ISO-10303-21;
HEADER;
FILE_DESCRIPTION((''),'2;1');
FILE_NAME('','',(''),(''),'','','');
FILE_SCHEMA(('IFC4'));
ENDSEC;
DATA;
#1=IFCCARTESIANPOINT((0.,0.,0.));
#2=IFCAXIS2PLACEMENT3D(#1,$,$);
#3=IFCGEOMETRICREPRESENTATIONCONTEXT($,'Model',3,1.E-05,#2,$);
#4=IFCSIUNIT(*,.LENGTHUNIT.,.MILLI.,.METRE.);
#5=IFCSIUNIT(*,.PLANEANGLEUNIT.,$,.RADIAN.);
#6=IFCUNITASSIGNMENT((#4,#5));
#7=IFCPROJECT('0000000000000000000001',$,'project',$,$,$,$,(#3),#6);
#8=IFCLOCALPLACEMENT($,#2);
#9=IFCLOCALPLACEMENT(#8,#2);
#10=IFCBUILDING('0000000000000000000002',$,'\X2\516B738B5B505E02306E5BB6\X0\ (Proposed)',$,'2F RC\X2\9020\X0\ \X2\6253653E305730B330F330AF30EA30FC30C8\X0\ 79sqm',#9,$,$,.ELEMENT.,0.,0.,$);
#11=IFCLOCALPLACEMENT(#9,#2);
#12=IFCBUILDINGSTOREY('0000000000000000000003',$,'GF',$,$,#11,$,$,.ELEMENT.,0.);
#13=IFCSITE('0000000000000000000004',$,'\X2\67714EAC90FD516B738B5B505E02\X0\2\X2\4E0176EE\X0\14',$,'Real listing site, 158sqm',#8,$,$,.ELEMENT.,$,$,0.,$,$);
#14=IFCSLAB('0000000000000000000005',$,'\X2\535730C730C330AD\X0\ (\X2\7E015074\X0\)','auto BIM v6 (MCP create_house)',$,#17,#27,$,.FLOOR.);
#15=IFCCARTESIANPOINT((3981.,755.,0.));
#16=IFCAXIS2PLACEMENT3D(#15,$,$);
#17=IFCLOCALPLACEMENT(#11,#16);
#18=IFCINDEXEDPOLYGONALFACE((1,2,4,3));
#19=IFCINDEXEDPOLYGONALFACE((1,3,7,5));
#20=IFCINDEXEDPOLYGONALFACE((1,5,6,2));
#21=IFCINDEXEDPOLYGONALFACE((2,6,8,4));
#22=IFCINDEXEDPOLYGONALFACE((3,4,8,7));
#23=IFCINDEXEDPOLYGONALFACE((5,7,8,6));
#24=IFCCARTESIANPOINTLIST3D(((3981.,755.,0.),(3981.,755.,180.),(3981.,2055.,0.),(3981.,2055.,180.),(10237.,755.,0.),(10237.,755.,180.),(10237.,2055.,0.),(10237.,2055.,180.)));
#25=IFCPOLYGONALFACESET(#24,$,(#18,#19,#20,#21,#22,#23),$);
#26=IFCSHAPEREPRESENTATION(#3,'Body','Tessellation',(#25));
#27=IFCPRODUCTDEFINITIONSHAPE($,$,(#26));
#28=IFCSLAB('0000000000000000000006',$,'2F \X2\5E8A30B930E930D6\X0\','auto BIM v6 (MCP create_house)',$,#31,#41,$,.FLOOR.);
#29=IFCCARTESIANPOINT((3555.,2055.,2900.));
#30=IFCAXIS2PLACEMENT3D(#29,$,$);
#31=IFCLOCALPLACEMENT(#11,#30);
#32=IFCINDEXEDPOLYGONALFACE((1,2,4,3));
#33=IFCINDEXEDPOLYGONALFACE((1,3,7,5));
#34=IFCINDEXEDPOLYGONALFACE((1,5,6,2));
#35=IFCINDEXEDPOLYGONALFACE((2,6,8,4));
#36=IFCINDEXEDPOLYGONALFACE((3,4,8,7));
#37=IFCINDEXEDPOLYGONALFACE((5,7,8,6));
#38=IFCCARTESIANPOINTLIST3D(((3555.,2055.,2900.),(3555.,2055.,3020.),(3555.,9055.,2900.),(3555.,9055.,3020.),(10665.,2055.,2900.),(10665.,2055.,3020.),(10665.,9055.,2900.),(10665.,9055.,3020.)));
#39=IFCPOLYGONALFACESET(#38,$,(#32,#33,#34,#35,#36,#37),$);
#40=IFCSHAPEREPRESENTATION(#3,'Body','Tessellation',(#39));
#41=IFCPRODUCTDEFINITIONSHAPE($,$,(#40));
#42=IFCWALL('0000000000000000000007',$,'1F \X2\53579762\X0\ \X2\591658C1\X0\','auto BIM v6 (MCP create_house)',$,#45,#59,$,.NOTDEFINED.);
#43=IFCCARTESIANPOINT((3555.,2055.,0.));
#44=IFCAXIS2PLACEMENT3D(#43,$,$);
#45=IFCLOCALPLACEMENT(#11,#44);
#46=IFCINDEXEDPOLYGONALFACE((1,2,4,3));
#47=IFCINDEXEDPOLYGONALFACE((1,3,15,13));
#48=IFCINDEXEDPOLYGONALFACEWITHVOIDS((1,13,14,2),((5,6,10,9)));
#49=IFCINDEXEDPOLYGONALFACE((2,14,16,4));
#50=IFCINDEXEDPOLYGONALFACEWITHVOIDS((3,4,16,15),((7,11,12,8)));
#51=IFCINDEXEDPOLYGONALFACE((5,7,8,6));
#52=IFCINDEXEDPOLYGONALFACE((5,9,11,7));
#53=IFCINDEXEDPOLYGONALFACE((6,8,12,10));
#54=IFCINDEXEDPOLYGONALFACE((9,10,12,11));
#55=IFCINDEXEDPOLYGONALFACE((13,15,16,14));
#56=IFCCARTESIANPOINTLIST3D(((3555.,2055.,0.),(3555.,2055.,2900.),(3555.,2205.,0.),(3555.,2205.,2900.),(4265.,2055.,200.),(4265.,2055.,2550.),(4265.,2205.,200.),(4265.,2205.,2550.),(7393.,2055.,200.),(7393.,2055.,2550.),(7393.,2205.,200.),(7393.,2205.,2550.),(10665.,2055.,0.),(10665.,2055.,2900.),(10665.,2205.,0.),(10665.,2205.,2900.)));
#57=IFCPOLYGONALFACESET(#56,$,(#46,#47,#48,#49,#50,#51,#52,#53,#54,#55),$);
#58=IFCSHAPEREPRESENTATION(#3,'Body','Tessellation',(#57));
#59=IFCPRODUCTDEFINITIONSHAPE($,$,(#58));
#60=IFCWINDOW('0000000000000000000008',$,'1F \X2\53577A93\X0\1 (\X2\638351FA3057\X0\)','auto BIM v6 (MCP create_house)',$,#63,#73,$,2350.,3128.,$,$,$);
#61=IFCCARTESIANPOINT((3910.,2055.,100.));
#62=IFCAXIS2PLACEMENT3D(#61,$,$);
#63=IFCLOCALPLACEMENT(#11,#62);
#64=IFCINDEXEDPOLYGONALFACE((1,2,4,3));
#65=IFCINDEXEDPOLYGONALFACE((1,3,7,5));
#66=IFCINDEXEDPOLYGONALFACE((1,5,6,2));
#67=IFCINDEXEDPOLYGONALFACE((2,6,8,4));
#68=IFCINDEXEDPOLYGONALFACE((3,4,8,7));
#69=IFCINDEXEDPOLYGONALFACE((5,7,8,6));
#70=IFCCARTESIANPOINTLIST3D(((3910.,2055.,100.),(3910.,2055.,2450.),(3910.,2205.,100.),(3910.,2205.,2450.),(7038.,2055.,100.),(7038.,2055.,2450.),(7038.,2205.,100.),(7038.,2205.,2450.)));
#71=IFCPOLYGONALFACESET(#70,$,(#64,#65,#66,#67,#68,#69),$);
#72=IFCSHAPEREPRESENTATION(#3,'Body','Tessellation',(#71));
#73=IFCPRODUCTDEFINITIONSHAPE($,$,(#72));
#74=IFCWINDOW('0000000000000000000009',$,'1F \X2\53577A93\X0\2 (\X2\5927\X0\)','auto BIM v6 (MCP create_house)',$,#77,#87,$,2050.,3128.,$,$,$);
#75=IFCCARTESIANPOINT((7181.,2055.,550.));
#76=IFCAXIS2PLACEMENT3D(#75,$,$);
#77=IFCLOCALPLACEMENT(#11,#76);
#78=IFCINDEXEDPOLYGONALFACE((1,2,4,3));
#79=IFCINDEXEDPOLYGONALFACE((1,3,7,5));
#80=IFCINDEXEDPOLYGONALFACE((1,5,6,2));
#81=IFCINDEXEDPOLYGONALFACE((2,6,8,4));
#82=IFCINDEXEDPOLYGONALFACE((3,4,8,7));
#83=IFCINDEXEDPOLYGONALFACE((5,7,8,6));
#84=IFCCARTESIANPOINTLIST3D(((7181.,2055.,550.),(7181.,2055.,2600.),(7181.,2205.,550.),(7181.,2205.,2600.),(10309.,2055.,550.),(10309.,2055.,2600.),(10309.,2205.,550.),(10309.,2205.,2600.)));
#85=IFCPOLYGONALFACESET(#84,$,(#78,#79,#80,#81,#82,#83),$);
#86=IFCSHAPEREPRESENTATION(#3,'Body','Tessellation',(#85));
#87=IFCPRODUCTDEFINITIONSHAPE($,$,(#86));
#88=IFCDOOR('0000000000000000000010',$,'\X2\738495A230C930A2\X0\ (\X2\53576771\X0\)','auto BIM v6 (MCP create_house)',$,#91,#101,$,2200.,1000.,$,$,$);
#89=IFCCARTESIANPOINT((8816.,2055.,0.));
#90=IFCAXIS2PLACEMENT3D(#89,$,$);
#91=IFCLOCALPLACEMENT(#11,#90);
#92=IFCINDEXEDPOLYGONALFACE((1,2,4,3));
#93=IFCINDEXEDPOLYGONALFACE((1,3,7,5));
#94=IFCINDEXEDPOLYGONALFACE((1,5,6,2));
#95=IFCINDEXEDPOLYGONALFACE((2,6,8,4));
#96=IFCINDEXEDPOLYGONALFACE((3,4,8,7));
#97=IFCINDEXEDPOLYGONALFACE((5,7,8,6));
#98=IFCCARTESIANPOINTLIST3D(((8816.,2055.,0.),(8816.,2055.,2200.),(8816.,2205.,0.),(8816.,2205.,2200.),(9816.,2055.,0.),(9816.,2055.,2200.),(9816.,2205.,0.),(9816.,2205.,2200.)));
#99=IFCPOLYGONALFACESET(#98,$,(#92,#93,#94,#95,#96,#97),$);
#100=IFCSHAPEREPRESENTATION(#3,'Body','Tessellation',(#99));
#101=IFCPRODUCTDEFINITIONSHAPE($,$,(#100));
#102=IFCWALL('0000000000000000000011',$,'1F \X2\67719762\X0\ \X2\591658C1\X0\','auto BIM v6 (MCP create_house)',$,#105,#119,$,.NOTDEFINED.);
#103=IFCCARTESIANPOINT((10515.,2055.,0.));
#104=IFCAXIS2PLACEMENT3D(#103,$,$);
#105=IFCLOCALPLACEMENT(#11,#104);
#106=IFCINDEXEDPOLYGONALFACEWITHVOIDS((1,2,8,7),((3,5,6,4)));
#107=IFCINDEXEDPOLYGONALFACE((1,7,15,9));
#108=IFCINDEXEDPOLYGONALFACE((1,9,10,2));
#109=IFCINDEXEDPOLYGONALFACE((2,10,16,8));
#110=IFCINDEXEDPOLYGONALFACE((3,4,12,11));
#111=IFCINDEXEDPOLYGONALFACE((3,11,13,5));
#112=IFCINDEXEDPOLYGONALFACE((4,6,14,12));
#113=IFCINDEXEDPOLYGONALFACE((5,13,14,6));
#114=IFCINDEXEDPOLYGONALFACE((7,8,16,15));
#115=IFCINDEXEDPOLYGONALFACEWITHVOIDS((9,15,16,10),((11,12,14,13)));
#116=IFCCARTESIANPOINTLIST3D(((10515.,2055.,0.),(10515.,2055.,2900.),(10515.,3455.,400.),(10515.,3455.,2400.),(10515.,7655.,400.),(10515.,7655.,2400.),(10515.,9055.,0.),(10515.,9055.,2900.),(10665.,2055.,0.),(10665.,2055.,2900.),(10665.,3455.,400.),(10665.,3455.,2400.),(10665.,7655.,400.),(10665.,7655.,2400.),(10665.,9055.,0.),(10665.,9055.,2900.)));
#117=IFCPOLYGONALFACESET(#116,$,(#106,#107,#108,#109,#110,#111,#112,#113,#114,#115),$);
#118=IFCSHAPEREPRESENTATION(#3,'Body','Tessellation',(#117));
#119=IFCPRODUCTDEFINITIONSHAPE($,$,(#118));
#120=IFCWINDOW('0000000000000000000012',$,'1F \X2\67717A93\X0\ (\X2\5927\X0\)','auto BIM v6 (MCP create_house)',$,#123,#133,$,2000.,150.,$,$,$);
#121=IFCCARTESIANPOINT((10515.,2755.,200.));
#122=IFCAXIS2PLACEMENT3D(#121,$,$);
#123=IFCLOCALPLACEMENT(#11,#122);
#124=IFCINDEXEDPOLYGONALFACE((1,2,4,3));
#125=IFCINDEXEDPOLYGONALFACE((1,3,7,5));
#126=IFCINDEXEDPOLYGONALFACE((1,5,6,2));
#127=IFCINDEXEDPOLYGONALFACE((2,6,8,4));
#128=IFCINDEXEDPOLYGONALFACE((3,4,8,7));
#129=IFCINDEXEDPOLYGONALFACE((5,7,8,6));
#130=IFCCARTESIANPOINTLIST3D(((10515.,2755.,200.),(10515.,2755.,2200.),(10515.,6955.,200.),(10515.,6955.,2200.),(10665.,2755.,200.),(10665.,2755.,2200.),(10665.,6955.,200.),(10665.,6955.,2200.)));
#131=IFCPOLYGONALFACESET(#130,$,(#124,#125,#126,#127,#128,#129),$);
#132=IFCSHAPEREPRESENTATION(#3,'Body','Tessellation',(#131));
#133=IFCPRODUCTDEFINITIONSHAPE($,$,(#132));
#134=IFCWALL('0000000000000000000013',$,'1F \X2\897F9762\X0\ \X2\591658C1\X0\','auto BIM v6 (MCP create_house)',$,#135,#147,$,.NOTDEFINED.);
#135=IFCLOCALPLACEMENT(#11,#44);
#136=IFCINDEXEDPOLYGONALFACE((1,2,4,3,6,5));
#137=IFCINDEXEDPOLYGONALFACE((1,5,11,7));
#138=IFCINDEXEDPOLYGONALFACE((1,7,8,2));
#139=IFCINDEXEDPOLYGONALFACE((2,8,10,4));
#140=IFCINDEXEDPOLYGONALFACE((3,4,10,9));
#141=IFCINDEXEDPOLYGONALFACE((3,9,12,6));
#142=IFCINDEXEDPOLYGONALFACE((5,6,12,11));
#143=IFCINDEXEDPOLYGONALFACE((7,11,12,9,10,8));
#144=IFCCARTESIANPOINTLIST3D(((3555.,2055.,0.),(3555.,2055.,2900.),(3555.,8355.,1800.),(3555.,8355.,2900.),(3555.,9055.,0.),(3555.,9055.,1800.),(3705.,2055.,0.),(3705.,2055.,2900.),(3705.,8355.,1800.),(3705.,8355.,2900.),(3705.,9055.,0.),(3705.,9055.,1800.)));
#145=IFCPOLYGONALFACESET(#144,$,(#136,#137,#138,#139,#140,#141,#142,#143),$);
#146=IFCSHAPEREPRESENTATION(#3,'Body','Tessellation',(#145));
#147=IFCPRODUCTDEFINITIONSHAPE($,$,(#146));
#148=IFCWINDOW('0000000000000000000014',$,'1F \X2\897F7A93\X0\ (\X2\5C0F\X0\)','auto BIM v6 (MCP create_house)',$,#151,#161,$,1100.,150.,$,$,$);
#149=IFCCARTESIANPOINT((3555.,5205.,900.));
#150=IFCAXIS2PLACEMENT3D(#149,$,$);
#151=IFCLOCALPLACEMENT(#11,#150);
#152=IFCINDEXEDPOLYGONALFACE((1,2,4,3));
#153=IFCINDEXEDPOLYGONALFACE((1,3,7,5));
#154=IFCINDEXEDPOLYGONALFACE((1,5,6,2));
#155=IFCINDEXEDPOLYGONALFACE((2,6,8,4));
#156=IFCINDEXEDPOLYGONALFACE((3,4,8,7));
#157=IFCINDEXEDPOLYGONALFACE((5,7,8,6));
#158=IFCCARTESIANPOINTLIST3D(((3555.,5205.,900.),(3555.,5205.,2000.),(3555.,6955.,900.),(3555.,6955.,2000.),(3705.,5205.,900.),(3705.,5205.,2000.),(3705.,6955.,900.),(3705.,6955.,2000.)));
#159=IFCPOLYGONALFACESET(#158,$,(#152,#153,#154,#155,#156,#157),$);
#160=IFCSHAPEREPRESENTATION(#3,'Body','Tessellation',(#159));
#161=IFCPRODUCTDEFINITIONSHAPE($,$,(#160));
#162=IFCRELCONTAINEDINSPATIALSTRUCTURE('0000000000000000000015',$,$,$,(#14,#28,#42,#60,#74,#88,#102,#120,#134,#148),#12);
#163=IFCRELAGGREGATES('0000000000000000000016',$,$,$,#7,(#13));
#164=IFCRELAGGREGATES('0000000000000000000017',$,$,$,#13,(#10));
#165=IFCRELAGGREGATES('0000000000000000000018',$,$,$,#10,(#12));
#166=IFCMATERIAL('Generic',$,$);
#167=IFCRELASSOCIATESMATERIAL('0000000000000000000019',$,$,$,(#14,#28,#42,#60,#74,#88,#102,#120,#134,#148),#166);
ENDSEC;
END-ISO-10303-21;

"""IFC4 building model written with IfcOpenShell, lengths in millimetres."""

from ifc_helpers import new_model, si_unit, frame, frame_2d, origin, place, context, project, spatial, rectangle, extrude, material, element, fill, save


model = new_model("IFC4")

# Units and contexts
model_context = context("Model", 3, precision=1e-05, world=origin())
ifc_project = project(units=[si_unit("LENGTHUNIT", "METRE", prefix="MILLI"), si_unit("PLANEANGLEUNIT", "RADIAN")], contexts=[model_context])

# Site, building, storey
site_placement = place(None, origin())
site = spatial("IfcSite", under=ifc_project, at=site_placement, Name="東京都八王子市2丁目14", ObjectType="Real listing site, 158sqm", CompositionType="ELEMENT", RefElevation=0.0)
building_placement = place(site_placement, origin())
building = spatial("IfcBuilding", under=site, at=building_placement, Name="八王子市の家 (Proposed)", ObjectType="2F RC造 打放しコンクリート 79sqm", CompositionType="ELEMENT", ElevationOfRefHeight=0.0, ElevationOfTerrain=0.0)
storey_placement = place(building_placement, origin())
storey = spatial("IfcBuildingStorey", under=building, at=storey_placement, Name="GF", CompositionType="ELEMENT", Elevation=0.0)

# Slabs
ifc_material = material(Name="Generic")
slab_1_placement = place(storey_placement, frame((3981.0, 755.0, 0.0)))
element("IfcSlab", 1, at=slab_1_placement, inside=storey, material=ifc_material, Name="南デッキ (縁側)", Description="auto BIM v6 (MCP create_house)", PredefinedType="FLOOR", context=model_context, shape_type="SweptSolid", body=[
    extrude(rectangle(XDim=6256.0, YDim=1300.0, at=frame_2d((3128.0, 650.0))), frame((3981.0, 755.0, 0.0)), (0.0, 0.0, 1.0), 180.0),
])
slab_2_placement = place(storey_placement, frame((3555.0, 2055.0, 2900.0)))
element("IfcSlab", 2, at=slab_2_placement, inside=storey, material=ifc_material, Name="2F 床スラブ", Description="auto BIM v6 (MCP create_house)", PredefinedType="FLOOR", context=model_context, shape_type="SweptSolid", body=[
    extrude(rectangle(XDim=7110.0, YDim=7000.0, at=frame_2d((3555.0, 3500.0))), frame((3555.0, 2055.0, 2900.0)), (0.0, 0.0, 1.0), 120.0),
])

# Wall, openings, windows, door
wall_1_placement = place(storey_placement, frame((3555.0, 2055.0, 0.0)))
wall_1 = element("IfcWall", 3, at=wall_1_placement, inside=storey, material=ifc_material, Name="1F 南面 外壁", Description="auto BIM v6 (MCP create_house)", PredefinedType="NOTDEFINED", context=model_context, shape_type="SweptSolid", body=[
    extrude(rectangle(XDim=7110.0, YDim=150.0, at=frame_2d((3555.0, 75.0))), frame((3555.0, 2055.0, 0.0)), (0.0, 0.0, 1.0), 2900.0),
])
opening_1_placement = place(storey_placement, frame((3910.0, 2055.0, 100.0)))
opening_1 = element("IfcOpeningElement", 4, at=opening_1_placement, cuts=wall_1, PredefinedType="NOTDEFINED", context=model_context, shape_type="SweptSolid", body=[
    extrude(rectangle(XDim=3128.0, YDim=150.0, at=frame_2d((1564.0, 75.0))), frame((3910.0, 2055.0, 100.0)), (0.0, 0.0, 1.0), 2350.0),
])
opening_2_placement = place(storey_placement, frame((7181.0, 2055.0, 550.0)))
opening_2 = element("IfcOpeningElement", 5, at=opening_2_placement, cuts=wall_1, PredefinedType="NOTDEFINED", context=model_context, shape_type="SweptSolid", body=[
    extrude(rectangle(XDim=3128.0, YDim=150.0, at=frame_2d((1564.0, 75.0))), frame((7181.0, 2055.0, 550.0)), (0.0, 0.0, 1.0), 2050.0),
])
opening_3_placement = place(storey_placement, frame((8816.0, 2055.0, 0.0)))
opening_3 = element("IfcOpeningElement", 6, at=opening_3_placement, cuts=wall_1, PredefinedType="NOTDEFINED", context=model_context, shape_type="SweptSolid", body=[
    extrude(rectangle(XDim=1000.0, YDim=150.0, at=frame_2d((500.0, 75.0))), frame((8816.0, 2055.0, 0.0)), (0.0, 0.0, 1.0), 2200.0),
])
window_1_placement = place(storey_placement, frame((3910.0, 2055.0, 100.0)))
window_1 = element("IfcWindow", 7, at=window_1_placement, inside=storey, material=ifc_material, Name="1F 南窓1 (掃出し)", Description="auto BIM v6 (MCP create_house)", OverallHeight=2350.0, OverallWidth=3128.0, context=model_context, shape_type="SweptSolid", body=[
    extrude(rectangle(XDim=3128.0, YDim=150.0, at=frame_2d((1564.0, 75.0))), frame((3910.0, 2055.0, 100.0)), (0.0, 0.0, 1.0), 2350.0),
])
fill(opening_1, window_1)
window_2_placement = place(storey_placement, frame((7181.0, 2055.0, 550.0)))
window_2 = element("IfcWindow", 8, at=window_2_placement, inside=storey, material=ifc_material, Name="1F 南窓2 (大)", Description="auto BIM v6 (MCP create_house)", OverallHeight=2050.0, OverallWidth=3128.0, context=model_context, shape_type="SweptSolid", body=[
    extrude(rectangle(XDim=3128.0, YDim=150.0, at=frame_2d((1564.0, 75.0))), frame((7181.0, 2055.0, 550.0)), (0.0, 0.0, 1.0), 2050.0),
])
fill(opening_2, window_2)
door_placement = place(storey_placement, frame((8816.0, 2055.0, 0.0)))
door = element("IfcDoor", 9, at=door_placement, inside=storey, material=ifc_material, Name="玄関ドア (南東)", Description="auto BIM v6 (MCP create_house)", OverallHeight=2200.0, OverallWidth=1000.0, context=model_context, shape_type="SweptSolid", body=[
    extrude(rectangle(XDim=1000.0, YDim=150.0, at=frame_2d((500.0, 75.0))), frame((8816.0, 2055.0, 0.0)), (0.0, 0.0, 1.0), 2200.0),
])
fill(opening_3, door)

# Walls, openings, windows
wall_2_placement = place(storey_placement, frame((10515.0, 2055.0, 0.0)))
wall_2 = element("IfcWall", 10, at=wall_2_placement, inside=storey, material=ifc_material, Name="1F 東面 外壁", Description="auto BIM v6 (MCP create_house)", PredefinedType="NOTDEFINED", context=model_context, shape_type="SweptSolid", body=[
    extrude(rectangle(XDim=150.0, YDim=7000.0, at=frame_2d((75.0, 3500.0))), frame((10515.0, 2055.0, 0.0)), (0.0, 0.0, 1.0), 2900.0),
])
opening_4_placement = place(storey_placement, frame((10515.0, 2755.0, 200.0)))
opening_4 = element("IfcOpeningElement", 11, at=opening_4_placement, cuts=wall_2, PredefinedType="NOTDEFINED", context=model_context, shape_type="SweptSolid", body=[
    extrude(rectangle(XDim=150.0, YDim=4200.0, at=frame_2d((75.0, 2100.0))), frame((10515.0, 2755.0, 200.0)), (0.0, 0.0, 1.0), 2000.0),
])
window_3_placement = place(storey_placement, frame((10515.0, 2755.0, 200.0)))
window_3 = element("IfcWindow", 12, at=window_3_placement, inside=storey, material=ifc_material, Name="1F 東窓 (大)", Description="auto BIM v6 (MCP create_house)", OverallHeight=2000.0, OverallWidth=150.0, context=model_context, shape_type="SweptSolid", body=[
    extrude(rectangle(XDim=150.0, YDim=4200.0, at=frame_2d((75.0, 2100.0))), frame((10515.0, 2755.0, 200.0)), (0.0, 0.0, 1.0), 2000.0),
])
fill(opening_4, window_3)
wall_3_placement = place(storey_placement, frame((3555.0, 2055.0, 0.0)))
wall_3 = element("IfcWall", 13, at=wall_3_placement, inside=storey, material=ifc_material, Name="1F 西面 外壁", Description="auto BIM v6 (MCP create_house)", PredefinedType="NOTDEFINED", context=model_context, shape_type="SweptSolid", body=[
    extrude(rectangle(XDim=150.0, YDim=7000.0, at=frame_2d((75.0, 3500.0))), frame((3555.0, 2055.0, 0.0)), (0.0, 0.0, 1.0), 2900.0),
])
opening_5_placement = place(storey_placement, frame((3555.0, 5205.0, 900.0)))
opening_5 = element("IfcOpeningElement", 14, at=opening_5_placement, cuts=wall_3, PredefinedType="NOTDEFINED", context=model_context, shape_type="SweptSolid", body=[
    extrude(rectangle(XDim=150.0, YDim=1750.0, at=frame_2d((75.0, 875.0))), frame((3555.0, 5205.0, 900.0)), (0.0, 0.0, 1.0), 1100.0),
])
window_4_placement = place(storey_placement, frame((3555.0, 5205.0, 900.0)))
window_4 = element("IfcWindow", 15, at=window_4_placement, inside=storey, material=ifc_material, Name="1F 西窓 (小)", Description="auto BIM v6 (MCP create_house)", OverallHeight=1100.0, OverallWidth=150.0, context=model_context, shape_type="SweptSolid", body=[
    extrude(rectangle(XDim=150.0, YDim=1750.0, at=frame_2d((75.0, 875.0))), frame((3555.0, 5205.0, 900.0)), (0.0, 0.0, 1.0), 1100.0),
])
fill(opening_5, window_4)

save(model, "model.ifc")
